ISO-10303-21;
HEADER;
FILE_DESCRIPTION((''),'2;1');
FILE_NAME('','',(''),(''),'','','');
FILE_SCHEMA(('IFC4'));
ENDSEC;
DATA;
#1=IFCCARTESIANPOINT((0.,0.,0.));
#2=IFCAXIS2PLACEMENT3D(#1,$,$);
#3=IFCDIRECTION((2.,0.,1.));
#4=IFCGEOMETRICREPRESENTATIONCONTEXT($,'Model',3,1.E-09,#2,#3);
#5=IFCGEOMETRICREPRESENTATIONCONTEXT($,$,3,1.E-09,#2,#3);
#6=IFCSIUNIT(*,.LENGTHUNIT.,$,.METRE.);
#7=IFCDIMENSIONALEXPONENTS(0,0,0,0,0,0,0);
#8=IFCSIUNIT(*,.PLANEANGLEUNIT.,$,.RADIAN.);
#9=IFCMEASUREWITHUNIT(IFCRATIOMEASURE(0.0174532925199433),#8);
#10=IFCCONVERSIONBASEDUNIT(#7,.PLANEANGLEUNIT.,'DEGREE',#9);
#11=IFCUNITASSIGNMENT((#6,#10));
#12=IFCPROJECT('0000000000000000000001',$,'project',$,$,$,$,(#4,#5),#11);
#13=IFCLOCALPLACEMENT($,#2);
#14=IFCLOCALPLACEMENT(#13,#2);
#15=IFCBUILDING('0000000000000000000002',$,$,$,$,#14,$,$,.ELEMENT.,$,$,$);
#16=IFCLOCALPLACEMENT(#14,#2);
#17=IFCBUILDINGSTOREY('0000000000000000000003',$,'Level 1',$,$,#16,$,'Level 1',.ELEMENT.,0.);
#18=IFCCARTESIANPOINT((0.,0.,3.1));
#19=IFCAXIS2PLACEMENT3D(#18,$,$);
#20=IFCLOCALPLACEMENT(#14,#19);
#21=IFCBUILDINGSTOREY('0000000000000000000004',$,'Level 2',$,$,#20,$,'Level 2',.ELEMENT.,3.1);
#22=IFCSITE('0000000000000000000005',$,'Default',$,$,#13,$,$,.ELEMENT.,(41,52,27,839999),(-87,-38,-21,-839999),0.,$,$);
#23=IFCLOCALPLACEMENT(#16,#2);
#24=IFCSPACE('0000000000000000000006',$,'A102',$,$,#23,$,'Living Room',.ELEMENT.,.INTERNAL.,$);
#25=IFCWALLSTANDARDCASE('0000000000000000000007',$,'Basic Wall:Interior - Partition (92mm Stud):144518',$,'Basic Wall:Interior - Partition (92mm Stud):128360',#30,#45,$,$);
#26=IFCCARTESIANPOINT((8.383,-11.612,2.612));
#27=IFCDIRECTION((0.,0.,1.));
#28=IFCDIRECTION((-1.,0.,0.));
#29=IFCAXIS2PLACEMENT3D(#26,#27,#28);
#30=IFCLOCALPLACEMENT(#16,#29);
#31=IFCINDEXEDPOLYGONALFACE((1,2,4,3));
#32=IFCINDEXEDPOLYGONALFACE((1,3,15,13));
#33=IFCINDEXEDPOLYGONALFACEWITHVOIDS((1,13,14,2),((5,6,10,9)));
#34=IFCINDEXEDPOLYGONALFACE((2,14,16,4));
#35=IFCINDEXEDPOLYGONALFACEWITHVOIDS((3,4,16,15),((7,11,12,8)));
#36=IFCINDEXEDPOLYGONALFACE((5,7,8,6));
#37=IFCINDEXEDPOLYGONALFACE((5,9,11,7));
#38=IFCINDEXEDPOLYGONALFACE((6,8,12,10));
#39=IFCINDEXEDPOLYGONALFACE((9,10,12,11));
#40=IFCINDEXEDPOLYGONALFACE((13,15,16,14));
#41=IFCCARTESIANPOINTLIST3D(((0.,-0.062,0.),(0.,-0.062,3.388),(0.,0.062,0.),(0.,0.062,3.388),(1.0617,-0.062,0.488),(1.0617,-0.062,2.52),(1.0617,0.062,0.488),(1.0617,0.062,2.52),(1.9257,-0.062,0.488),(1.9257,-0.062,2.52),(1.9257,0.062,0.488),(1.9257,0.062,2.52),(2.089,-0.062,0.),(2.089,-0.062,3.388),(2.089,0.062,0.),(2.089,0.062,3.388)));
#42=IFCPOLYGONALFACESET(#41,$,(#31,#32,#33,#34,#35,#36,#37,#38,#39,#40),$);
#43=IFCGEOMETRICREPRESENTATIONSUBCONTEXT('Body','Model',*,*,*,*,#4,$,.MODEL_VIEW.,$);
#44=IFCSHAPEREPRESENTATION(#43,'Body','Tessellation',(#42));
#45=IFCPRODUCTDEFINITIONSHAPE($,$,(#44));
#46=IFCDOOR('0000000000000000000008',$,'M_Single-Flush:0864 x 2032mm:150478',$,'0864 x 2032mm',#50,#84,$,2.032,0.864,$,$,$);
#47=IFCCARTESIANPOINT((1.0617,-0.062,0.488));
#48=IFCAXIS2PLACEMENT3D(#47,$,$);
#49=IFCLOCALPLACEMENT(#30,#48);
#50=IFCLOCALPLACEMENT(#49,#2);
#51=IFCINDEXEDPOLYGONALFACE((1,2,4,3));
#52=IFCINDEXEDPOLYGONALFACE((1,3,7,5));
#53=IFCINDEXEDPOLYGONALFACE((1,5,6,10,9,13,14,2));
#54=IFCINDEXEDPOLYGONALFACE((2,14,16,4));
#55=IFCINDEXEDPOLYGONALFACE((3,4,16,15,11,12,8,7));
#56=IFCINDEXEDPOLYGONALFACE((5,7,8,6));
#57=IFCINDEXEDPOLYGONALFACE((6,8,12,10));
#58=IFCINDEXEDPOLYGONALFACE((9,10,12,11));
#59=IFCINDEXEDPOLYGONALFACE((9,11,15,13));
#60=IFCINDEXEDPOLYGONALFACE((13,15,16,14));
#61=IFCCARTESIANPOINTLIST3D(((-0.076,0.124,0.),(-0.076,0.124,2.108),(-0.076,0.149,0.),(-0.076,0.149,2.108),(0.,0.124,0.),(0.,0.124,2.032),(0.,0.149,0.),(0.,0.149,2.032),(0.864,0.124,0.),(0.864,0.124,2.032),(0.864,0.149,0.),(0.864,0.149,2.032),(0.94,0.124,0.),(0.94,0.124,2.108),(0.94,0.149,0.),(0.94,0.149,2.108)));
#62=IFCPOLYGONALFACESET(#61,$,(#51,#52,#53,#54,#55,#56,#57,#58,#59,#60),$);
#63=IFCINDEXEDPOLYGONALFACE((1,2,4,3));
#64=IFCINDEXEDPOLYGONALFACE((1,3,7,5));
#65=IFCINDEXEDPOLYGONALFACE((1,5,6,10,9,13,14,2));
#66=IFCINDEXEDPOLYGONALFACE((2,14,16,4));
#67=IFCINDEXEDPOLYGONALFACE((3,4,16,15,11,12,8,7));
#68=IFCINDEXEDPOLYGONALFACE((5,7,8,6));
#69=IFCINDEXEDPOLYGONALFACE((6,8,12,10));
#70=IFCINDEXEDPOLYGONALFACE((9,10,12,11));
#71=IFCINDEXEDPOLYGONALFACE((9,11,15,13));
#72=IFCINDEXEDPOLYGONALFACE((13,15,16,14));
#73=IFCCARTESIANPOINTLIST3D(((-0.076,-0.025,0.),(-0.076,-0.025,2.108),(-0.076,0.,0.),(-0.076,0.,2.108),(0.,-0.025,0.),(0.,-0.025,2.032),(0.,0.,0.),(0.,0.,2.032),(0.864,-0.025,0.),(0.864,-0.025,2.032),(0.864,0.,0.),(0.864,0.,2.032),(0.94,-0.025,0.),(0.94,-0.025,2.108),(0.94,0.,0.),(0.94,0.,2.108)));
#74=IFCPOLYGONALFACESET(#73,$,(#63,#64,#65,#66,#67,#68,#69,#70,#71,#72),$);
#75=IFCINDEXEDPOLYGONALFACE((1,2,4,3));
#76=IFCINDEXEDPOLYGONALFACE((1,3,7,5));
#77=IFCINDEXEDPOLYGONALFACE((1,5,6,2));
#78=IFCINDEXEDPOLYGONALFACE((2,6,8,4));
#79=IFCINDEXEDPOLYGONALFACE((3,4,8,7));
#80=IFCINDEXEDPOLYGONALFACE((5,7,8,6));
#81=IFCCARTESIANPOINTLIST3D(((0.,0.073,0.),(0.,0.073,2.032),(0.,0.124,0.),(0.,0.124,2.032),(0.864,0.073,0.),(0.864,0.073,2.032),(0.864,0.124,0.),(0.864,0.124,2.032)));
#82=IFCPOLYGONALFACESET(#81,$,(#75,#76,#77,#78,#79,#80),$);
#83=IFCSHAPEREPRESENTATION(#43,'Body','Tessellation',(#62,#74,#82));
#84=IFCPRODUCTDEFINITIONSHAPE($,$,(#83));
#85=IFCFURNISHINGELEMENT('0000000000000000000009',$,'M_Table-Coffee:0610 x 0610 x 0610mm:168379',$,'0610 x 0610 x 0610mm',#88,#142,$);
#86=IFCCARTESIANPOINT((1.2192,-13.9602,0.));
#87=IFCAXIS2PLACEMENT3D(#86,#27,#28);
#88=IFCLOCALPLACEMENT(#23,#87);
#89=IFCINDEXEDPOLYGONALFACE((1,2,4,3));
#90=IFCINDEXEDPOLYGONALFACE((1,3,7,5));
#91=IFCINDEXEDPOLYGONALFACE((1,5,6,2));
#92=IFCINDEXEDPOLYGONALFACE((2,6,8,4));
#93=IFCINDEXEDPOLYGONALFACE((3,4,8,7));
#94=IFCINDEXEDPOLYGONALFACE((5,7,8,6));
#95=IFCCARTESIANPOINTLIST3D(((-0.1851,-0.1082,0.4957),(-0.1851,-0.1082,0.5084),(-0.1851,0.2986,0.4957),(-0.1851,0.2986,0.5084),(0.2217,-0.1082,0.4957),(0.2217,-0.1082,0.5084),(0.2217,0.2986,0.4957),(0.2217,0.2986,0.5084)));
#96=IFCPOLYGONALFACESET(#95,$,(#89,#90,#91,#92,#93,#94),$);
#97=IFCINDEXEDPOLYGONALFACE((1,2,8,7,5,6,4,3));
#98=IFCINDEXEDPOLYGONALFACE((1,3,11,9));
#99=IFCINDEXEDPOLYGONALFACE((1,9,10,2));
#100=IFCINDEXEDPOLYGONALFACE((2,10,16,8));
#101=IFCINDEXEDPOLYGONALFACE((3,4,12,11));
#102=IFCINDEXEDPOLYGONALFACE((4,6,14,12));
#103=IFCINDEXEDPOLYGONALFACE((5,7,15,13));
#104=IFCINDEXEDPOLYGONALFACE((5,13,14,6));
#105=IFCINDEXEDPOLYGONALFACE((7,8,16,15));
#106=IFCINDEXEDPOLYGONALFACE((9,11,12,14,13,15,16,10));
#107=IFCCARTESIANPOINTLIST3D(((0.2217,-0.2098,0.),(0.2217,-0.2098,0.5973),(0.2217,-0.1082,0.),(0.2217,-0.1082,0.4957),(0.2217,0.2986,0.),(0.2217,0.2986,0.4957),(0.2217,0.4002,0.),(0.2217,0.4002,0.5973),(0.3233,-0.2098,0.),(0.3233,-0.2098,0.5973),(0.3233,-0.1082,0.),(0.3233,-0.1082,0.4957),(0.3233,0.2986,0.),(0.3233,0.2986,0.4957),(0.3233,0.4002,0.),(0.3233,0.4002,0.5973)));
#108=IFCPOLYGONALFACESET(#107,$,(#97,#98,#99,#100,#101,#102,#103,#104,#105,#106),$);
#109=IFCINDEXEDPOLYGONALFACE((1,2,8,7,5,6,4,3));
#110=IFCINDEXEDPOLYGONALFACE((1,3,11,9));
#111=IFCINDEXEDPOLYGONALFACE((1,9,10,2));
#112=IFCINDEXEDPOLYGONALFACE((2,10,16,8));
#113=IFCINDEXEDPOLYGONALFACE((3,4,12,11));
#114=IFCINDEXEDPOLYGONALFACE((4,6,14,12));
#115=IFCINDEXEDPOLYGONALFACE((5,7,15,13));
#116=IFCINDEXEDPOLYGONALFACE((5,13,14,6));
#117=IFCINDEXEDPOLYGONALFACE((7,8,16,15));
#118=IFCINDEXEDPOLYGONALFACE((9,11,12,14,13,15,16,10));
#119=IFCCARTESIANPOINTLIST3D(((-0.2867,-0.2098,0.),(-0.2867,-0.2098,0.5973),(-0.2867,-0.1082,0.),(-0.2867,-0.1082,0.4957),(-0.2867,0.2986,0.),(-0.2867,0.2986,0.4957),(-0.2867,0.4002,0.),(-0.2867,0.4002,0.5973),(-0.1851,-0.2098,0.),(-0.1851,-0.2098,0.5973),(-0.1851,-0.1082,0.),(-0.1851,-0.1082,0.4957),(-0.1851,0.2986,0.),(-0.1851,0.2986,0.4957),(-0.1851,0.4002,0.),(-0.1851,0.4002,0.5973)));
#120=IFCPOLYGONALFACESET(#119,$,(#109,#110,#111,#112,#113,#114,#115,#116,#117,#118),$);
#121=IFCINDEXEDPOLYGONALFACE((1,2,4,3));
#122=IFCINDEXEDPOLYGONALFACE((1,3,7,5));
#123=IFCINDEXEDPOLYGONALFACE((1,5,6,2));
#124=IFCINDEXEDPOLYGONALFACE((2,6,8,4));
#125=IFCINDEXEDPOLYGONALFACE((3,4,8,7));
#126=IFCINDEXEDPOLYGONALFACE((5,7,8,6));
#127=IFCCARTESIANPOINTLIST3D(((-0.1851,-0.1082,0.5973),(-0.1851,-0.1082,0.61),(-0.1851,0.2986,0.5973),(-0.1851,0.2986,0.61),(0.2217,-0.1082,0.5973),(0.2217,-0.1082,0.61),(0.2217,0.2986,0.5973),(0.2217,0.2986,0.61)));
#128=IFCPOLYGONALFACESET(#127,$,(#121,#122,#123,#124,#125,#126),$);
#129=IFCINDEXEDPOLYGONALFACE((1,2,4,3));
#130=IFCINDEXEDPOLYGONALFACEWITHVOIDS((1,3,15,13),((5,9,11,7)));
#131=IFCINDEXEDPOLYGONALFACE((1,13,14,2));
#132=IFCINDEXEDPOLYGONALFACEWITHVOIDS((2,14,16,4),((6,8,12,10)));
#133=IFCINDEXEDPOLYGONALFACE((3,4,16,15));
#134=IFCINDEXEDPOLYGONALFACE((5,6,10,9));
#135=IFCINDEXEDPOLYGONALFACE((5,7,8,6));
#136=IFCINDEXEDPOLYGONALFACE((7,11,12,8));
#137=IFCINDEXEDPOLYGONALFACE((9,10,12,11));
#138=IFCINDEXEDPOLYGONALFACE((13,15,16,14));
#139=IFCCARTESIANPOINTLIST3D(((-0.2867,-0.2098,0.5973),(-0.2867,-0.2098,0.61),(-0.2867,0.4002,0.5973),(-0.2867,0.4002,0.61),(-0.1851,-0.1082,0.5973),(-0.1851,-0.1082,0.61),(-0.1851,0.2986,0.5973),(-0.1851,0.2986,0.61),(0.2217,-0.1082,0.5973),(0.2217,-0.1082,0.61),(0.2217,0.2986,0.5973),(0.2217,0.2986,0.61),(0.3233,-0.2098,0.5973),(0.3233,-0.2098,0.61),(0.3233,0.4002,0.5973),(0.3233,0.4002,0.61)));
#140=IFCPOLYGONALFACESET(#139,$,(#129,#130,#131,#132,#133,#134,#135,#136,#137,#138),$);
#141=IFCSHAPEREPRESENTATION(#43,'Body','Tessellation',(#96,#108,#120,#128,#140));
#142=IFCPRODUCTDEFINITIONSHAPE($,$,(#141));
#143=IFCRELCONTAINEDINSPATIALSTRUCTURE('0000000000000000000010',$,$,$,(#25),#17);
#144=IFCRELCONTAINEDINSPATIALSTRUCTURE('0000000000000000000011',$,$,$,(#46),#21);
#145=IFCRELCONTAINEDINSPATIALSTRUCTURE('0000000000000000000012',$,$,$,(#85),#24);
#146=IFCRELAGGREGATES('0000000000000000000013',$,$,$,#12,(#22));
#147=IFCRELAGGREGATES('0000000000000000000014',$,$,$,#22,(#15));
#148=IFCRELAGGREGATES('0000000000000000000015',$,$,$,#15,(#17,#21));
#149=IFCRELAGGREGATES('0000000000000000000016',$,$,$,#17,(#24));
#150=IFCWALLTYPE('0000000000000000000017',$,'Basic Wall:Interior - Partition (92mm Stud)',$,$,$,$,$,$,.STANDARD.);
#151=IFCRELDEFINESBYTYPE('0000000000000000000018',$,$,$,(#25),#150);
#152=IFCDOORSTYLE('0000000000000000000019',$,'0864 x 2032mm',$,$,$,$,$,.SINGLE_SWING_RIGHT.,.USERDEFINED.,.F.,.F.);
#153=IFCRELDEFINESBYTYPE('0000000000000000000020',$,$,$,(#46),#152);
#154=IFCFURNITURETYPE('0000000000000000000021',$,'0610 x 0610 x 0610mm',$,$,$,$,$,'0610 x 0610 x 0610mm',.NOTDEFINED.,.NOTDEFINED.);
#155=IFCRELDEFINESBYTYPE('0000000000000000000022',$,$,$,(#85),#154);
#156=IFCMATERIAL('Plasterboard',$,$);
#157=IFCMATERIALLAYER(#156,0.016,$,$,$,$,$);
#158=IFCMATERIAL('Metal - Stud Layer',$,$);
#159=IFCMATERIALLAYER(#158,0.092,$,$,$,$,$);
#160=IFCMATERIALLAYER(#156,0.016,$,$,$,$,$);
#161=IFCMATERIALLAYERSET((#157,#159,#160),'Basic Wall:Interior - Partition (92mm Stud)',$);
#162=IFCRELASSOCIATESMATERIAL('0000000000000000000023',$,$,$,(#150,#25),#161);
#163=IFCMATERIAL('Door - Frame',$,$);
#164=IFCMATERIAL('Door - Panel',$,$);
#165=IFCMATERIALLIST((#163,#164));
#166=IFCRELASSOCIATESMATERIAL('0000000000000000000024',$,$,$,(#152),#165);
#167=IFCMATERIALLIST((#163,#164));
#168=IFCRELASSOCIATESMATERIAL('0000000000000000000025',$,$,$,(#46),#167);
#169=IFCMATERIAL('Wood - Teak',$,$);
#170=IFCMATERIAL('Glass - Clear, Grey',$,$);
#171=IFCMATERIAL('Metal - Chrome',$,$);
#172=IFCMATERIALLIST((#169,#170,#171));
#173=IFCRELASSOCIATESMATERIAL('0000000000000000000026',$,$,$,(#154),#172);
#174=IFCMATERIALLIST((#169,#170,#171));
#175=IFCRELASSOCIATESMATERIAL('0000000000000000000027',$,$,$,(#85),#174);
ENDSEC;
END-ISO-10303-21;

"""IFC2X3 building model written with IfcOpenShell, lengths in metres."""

from ifc_helpers import new_model, entity, si_unit, converted_unit, direction, frame, frame_2d, origin, origin_2d_with_axis, place, context, subcontext, project, spatial, polyline, rectangle, outline, extrude, source, transform, mapped, material, material_list, layer, layer_set, layer_usage, type_object, type_shapes, element, fill, save


model = new_model("IFC2X3")

# Units and contexts
model_context = context("Model", 3, precision=1e-09, world=origin(), true_north=direction((2.0, 0.0, 1.0)))
context_of_model = context(None, 3, precision=1e-09, world=origin(), true_north=direction((2.0, 0.0, 1.0)))
body_context = subcontext(model_context, "Body", "Model", "MODEL_VIEW")
ifc_project = project(units=[si_unit("LENGTHUNIT", "METRE"), converted_unit("PLANEANGLEUNIT", "DEGREE", entity("IfcRatioMeasure", 0.0174532925199433), si_unit("PLANEANGLEUNIT", "RADIAN"), dimensions=[0, 0, 0, 0, 0, 0, 0])], contexts=[model_context, context_of_model])

# Site, building, storey
site_placement = place(None, origin())
site = spatial("IfcSite", under=ifc_project, at=site_placement, Name="Default", CompositionType="ELEMENT", RefLatitude=(41, 52, 27, 839999), RefLongitude=(-87, -38, -21, -839999), RefElevation=0.0)
building_placement = place(site_placement, origin())
building = spatial("IfcBuilding", under=site, at=building_placement, CompositionType="ELEMENT")
storey_1_placement = place(building_placement, origin())
storey_1 = spatial("IfcBuildingStorey", under=building, at=storey_1_placement, Name="Level 1", LongName="Level 1", CompositionType="ELEMENT", Elevation=0.0)

# Shared definitions
ifc_material_1 = material(Name="Metal - Stud Layer")
ifc_material_2 = material(Name="Plasterboard")
ifc_material_3 = material(Name="Door - Frame")
ifc_material_4 = material(Name="Door - Panel")

# Shared definitions
ifc_layer_1 = layer(ifc_material_2, 0.016)
ifc_layer_2 = layer(ifc_material_1, 0.092)
ifc_layer_3 = layer(ifc_material_2, 0.016)
ifc_layer_set_1 = layer_set([ifc_layer_1, ifc_layer_2, ifc_layer_3], Name="Basic Wall:Interior - Partition (92mm Stud)")
wall_type_1 = type_object("IfcWallType", Name="Basic Wall:Interior - Partition (92mm Stud)", PredefinedType="STANDARD", material=ifc_layer_set_1)

# Wall, opening
ifc_layer_usage_1 = layer_usage(ifc_layer_set_1, "AXIS2", "NEGATIVE", 0.062)
wall_1_placement = place(storey_1_placement, frame((8.383, -11.612, 2.612), z_axis=(0.0, 0.0, 1.0), x_axis=(-1.0, 0.0, 0.0)))
wall_1 = element("IfcWallStandardCase", 1, at=wall_1_placement, inside=storey_1, type_object=wall_type_1, material=ifc_layer_usage_1, Name="Basic Wall:Interior - Partition (92mm Stud):144518", ObjectType="Basic Wall:Interior - Partition (92mm Stud):128360", context=body_context, shape_type="SweptSolid", body=[
    extrude(rectangle(XDim=2.089, YDim=0.124, at=frame_2d((1.0445, 0.0), x_axis=(-1.0, 0.0))), origin(), (0.0, 0.0, 1.0), 3.388),
])
opening_1_placement = place(wall_1_placement, frame((1.0617, -0.062, 0.488)))
opening_1 = element("IfcOpeningElement", 2, at=opening_1_placement, cuts=wall_1, ObjectType="Opening", context=body_context, shape_type="SweptSolid", body=[
    extrude(rectangle(XDim=0.864, YDim=2.032, at=frame_2d((1.016, 0.432), x_axis=(0.0, 1.0))), frame((0.0, 0.0, 0.0), z_axis=(0.0, 1.0, 0.0), x_axis=(0.0, 0.0, 1.0)), (0.0, 0.0, 1.0), 0.124),
])

# Shared definitions
storey_2_placement = place(building_placement, frame((0.0, 0.0, 3.1)))
storey_2 = spatial("IfcBuildingStorey", under=building, at=storey_2_placement, Name="Level 2", LongName="Level 2", CompositionType="ELEMENT", Elevation=3.1)

# Door
ifc_material_list_1 = material_list([ifc_material_3, ifc_material_4])
ifc_material_list_2 = material_list([ifc_material_3, ifc_material_4])
door_style_1 = type_object("IfcDoorStyle", Name="0864 x 2032mm", ConstructionType="USERDEFINED", OperationType="SINGLE_SWING_RIGHT", ParameterTakesPrecedence=False, Sizeable=False, material=ifc_material_list_2)
shared_shape_1 = source(origin(), body_context, "Body", "SweptSolid", [
    extrude(outline(polyline([(-0.508, -1.073), (0.508, -1.073), (0.508, 1.035), (0.432, 1.035), (0.432, -0.997), (-0.432, -0.997), (-0.432, 1.035), (-0.508, 1.035), (-0.508, -1.073)])), frame((0.432, 0.124, 1.035), z_axis=(0.0, 1.0, 0.0), x_axis=(1.0, 0.0, 0.0)), (0.0, 0.0, 1.0), 0.025),
    extrude(outline(polyline([(-1.073, -0.508), (1.035, -0.508), (1.035, -0.432), (-0.997, -0.432), (-0.997, 0.432), (1.035, 0.432), (1.035, 0.508), (-1.073, 0.508), (-1.073, -0.508)])), frame((0.432, -0.025, 1.035), z_axis=(0.0, 1.0, 0.0), x_axis=(0.0, 0.0, -1.0)), (0.0, 0.0, 1.0), 0.025),
    extrude(rectangle(XDim=0.051, YDim=0.864, at=origin_2d_with_axis()), frame((0.432, 0.0985, 0.0), z_axis=(0.0, 0.0, 1.0), x_axis=(0.0, 1.0, 0.0)), (0.0, 0.0, 1.0), 2.032),
])
type_shapes(door_style_1, [shared_shape_1])
door_1_placement = place(opening_1_placement, origin())
door_1 = element("IfcDoor", 3, at=door_1_placement, inside=storey_2, type_object=door_style_1, material=ifc_material_list_1, Name="M_Single-Flush:0864 x 2032mm:150478", ObjectType="0864 x 2032mm", OverallHeight=2.032, OverallWidth=0.864, context=body_context, shape_type="MappedRepresentation", body=[
    mapped(shared_shape_1, transform((0.0, 0.0, 0.0), scale=1.0)),
])
fill(opening_1, door_1)

# Shared definitions
space_1_placement = place(storey_1_placement, origin())
space_1 = spatial("IfcSpace", under=storey_1, at=space_1_placement, Name="A102", LongName="Living Room", CompositionType="ELEMENT", InteriorOrExteriorSpace="INTERNAL")

# Furnishing element
ifc_material_5 = material(Name="Wood - Teak")
ifc_material_6 = material(Name="Glass - Clear, Grey")
ifc_material_7 = material(Name="Metal - Chrome")
ifc_material_list_3 = material_list([ifc_material_5, ifc_material_6, ifc_material_7])
ifc_material_list_4 = material_list([ifc_material_5, ifc_material_6, ifc_material_7])
furniture_type_1 = type_object("IfcFurnitureType", Name="0610 x 0610 x 0610mm", ElementType="0610 x 0610 x 0610mm", AssemblyPlace="NOTDEFINED", material=ifc_material_list_4)
shared_shape_2 = source(origin(), body_context, "Body", "SweptSolid", [
    extrude(rectangle(XDim=0.4068, YDim=0.4068, at=origin_2d_with_axis()), frame((0.0183, 0.0952, 0.4957), z_axis=(0.0, 0.0, 1.0), x_axis=(-1.0, 0.0, 0.0)), (0.0, 0.0, 1.0), 0.0127),
    extrude(outline(polyline([(-0.2732, -0.305), (0.324, -0.305), (0.324, 0.305), (-0.2732, 0.305), (-0.2732, 0.2034), (0.2225, 0.2034), (0.2225, -0.2034), (-0.2732, -0.2034), (-0.2732, -0.305)])), frame((0.2217, 0.0952, 0.2732), z_axis=(1.0, 0.0, 0.0), x_axis=(0.0, 0.0, 1.0)), (0.0, 0.0, 1.0), 0.1016),
    extrude(outline(polyline([(-0.305, -0.3241), (0.305, -0.3241), (0.305, 0.2733), (0.2034, 0.2733), (0.2034, -0.2224), (-0.2034, -0.2224), (-0.2034, 0.2733), (-0.305, 0.2733), (-0.305, -0.3241)])), frame((-0.2867, 0.0952, 0.2733), z_axis=(1.0, 0.0, 0.0), x_axis=(0.0, -1.0, 0.0)), (0.0, 0.0, 1.0), 0.1016),
    extrude(rectangle(XDim=0.4068, YDim=0.4068, at=origin_2d_with_axis()), frame((0.0183, 0.0952, 0.5973), z_axis=(0.0, 0.0, 1.0), x_axis=(-1.0, 0.0, 0.0)), (0.0, 0.0, 1.0), 0.0127),
    extrude(outline(polyline([(-0.305, -0.305), (0.305, -0.305), (0.305, 0.305), (-0.305, 0.305), (-0.305, -0.305)]), holes=[polyline([(-0.2034, -0.2034), (-0.2034, 0.2034), (0.2034, 0.2034), (0.2034, -0.2034), (-0.2034, -0.2034)])]), frame((0.0183, 0.0952, 0.5973), z_axis=(0.0, 0.0, 1.0), x_axis=(-1.0, 0.0, 0.0)), (0.0, 0.0, 1.0), 0.0127),
])
type_shapes(furniture_type_1, [shared_shape_2])
furnishing_1_placement = place(space_1_placement, frame((1.2192, -13.9602, 0.0), z_axis=(0.0, 0.0, 1.0), x_axis=(-1.0, 0.0, 0.0)))
element("IfcFurnishingElement", 4, at=furnishing_1_placement, inside=space_1, type_object=furniture_type_1, material=ifc_material_list_3, Name="M_Table-Coffee:0610 x 0610 x 0610mm:168379", ObjectType="0610 x 0610 x 0610mm", context=body_context, shape_type="MappedRepresentation", body=[
    mapped(shared_shape_2, transform((0.0, 0.0, 0.0), scale=1.0)),
])

save(model, "model.ifc")
